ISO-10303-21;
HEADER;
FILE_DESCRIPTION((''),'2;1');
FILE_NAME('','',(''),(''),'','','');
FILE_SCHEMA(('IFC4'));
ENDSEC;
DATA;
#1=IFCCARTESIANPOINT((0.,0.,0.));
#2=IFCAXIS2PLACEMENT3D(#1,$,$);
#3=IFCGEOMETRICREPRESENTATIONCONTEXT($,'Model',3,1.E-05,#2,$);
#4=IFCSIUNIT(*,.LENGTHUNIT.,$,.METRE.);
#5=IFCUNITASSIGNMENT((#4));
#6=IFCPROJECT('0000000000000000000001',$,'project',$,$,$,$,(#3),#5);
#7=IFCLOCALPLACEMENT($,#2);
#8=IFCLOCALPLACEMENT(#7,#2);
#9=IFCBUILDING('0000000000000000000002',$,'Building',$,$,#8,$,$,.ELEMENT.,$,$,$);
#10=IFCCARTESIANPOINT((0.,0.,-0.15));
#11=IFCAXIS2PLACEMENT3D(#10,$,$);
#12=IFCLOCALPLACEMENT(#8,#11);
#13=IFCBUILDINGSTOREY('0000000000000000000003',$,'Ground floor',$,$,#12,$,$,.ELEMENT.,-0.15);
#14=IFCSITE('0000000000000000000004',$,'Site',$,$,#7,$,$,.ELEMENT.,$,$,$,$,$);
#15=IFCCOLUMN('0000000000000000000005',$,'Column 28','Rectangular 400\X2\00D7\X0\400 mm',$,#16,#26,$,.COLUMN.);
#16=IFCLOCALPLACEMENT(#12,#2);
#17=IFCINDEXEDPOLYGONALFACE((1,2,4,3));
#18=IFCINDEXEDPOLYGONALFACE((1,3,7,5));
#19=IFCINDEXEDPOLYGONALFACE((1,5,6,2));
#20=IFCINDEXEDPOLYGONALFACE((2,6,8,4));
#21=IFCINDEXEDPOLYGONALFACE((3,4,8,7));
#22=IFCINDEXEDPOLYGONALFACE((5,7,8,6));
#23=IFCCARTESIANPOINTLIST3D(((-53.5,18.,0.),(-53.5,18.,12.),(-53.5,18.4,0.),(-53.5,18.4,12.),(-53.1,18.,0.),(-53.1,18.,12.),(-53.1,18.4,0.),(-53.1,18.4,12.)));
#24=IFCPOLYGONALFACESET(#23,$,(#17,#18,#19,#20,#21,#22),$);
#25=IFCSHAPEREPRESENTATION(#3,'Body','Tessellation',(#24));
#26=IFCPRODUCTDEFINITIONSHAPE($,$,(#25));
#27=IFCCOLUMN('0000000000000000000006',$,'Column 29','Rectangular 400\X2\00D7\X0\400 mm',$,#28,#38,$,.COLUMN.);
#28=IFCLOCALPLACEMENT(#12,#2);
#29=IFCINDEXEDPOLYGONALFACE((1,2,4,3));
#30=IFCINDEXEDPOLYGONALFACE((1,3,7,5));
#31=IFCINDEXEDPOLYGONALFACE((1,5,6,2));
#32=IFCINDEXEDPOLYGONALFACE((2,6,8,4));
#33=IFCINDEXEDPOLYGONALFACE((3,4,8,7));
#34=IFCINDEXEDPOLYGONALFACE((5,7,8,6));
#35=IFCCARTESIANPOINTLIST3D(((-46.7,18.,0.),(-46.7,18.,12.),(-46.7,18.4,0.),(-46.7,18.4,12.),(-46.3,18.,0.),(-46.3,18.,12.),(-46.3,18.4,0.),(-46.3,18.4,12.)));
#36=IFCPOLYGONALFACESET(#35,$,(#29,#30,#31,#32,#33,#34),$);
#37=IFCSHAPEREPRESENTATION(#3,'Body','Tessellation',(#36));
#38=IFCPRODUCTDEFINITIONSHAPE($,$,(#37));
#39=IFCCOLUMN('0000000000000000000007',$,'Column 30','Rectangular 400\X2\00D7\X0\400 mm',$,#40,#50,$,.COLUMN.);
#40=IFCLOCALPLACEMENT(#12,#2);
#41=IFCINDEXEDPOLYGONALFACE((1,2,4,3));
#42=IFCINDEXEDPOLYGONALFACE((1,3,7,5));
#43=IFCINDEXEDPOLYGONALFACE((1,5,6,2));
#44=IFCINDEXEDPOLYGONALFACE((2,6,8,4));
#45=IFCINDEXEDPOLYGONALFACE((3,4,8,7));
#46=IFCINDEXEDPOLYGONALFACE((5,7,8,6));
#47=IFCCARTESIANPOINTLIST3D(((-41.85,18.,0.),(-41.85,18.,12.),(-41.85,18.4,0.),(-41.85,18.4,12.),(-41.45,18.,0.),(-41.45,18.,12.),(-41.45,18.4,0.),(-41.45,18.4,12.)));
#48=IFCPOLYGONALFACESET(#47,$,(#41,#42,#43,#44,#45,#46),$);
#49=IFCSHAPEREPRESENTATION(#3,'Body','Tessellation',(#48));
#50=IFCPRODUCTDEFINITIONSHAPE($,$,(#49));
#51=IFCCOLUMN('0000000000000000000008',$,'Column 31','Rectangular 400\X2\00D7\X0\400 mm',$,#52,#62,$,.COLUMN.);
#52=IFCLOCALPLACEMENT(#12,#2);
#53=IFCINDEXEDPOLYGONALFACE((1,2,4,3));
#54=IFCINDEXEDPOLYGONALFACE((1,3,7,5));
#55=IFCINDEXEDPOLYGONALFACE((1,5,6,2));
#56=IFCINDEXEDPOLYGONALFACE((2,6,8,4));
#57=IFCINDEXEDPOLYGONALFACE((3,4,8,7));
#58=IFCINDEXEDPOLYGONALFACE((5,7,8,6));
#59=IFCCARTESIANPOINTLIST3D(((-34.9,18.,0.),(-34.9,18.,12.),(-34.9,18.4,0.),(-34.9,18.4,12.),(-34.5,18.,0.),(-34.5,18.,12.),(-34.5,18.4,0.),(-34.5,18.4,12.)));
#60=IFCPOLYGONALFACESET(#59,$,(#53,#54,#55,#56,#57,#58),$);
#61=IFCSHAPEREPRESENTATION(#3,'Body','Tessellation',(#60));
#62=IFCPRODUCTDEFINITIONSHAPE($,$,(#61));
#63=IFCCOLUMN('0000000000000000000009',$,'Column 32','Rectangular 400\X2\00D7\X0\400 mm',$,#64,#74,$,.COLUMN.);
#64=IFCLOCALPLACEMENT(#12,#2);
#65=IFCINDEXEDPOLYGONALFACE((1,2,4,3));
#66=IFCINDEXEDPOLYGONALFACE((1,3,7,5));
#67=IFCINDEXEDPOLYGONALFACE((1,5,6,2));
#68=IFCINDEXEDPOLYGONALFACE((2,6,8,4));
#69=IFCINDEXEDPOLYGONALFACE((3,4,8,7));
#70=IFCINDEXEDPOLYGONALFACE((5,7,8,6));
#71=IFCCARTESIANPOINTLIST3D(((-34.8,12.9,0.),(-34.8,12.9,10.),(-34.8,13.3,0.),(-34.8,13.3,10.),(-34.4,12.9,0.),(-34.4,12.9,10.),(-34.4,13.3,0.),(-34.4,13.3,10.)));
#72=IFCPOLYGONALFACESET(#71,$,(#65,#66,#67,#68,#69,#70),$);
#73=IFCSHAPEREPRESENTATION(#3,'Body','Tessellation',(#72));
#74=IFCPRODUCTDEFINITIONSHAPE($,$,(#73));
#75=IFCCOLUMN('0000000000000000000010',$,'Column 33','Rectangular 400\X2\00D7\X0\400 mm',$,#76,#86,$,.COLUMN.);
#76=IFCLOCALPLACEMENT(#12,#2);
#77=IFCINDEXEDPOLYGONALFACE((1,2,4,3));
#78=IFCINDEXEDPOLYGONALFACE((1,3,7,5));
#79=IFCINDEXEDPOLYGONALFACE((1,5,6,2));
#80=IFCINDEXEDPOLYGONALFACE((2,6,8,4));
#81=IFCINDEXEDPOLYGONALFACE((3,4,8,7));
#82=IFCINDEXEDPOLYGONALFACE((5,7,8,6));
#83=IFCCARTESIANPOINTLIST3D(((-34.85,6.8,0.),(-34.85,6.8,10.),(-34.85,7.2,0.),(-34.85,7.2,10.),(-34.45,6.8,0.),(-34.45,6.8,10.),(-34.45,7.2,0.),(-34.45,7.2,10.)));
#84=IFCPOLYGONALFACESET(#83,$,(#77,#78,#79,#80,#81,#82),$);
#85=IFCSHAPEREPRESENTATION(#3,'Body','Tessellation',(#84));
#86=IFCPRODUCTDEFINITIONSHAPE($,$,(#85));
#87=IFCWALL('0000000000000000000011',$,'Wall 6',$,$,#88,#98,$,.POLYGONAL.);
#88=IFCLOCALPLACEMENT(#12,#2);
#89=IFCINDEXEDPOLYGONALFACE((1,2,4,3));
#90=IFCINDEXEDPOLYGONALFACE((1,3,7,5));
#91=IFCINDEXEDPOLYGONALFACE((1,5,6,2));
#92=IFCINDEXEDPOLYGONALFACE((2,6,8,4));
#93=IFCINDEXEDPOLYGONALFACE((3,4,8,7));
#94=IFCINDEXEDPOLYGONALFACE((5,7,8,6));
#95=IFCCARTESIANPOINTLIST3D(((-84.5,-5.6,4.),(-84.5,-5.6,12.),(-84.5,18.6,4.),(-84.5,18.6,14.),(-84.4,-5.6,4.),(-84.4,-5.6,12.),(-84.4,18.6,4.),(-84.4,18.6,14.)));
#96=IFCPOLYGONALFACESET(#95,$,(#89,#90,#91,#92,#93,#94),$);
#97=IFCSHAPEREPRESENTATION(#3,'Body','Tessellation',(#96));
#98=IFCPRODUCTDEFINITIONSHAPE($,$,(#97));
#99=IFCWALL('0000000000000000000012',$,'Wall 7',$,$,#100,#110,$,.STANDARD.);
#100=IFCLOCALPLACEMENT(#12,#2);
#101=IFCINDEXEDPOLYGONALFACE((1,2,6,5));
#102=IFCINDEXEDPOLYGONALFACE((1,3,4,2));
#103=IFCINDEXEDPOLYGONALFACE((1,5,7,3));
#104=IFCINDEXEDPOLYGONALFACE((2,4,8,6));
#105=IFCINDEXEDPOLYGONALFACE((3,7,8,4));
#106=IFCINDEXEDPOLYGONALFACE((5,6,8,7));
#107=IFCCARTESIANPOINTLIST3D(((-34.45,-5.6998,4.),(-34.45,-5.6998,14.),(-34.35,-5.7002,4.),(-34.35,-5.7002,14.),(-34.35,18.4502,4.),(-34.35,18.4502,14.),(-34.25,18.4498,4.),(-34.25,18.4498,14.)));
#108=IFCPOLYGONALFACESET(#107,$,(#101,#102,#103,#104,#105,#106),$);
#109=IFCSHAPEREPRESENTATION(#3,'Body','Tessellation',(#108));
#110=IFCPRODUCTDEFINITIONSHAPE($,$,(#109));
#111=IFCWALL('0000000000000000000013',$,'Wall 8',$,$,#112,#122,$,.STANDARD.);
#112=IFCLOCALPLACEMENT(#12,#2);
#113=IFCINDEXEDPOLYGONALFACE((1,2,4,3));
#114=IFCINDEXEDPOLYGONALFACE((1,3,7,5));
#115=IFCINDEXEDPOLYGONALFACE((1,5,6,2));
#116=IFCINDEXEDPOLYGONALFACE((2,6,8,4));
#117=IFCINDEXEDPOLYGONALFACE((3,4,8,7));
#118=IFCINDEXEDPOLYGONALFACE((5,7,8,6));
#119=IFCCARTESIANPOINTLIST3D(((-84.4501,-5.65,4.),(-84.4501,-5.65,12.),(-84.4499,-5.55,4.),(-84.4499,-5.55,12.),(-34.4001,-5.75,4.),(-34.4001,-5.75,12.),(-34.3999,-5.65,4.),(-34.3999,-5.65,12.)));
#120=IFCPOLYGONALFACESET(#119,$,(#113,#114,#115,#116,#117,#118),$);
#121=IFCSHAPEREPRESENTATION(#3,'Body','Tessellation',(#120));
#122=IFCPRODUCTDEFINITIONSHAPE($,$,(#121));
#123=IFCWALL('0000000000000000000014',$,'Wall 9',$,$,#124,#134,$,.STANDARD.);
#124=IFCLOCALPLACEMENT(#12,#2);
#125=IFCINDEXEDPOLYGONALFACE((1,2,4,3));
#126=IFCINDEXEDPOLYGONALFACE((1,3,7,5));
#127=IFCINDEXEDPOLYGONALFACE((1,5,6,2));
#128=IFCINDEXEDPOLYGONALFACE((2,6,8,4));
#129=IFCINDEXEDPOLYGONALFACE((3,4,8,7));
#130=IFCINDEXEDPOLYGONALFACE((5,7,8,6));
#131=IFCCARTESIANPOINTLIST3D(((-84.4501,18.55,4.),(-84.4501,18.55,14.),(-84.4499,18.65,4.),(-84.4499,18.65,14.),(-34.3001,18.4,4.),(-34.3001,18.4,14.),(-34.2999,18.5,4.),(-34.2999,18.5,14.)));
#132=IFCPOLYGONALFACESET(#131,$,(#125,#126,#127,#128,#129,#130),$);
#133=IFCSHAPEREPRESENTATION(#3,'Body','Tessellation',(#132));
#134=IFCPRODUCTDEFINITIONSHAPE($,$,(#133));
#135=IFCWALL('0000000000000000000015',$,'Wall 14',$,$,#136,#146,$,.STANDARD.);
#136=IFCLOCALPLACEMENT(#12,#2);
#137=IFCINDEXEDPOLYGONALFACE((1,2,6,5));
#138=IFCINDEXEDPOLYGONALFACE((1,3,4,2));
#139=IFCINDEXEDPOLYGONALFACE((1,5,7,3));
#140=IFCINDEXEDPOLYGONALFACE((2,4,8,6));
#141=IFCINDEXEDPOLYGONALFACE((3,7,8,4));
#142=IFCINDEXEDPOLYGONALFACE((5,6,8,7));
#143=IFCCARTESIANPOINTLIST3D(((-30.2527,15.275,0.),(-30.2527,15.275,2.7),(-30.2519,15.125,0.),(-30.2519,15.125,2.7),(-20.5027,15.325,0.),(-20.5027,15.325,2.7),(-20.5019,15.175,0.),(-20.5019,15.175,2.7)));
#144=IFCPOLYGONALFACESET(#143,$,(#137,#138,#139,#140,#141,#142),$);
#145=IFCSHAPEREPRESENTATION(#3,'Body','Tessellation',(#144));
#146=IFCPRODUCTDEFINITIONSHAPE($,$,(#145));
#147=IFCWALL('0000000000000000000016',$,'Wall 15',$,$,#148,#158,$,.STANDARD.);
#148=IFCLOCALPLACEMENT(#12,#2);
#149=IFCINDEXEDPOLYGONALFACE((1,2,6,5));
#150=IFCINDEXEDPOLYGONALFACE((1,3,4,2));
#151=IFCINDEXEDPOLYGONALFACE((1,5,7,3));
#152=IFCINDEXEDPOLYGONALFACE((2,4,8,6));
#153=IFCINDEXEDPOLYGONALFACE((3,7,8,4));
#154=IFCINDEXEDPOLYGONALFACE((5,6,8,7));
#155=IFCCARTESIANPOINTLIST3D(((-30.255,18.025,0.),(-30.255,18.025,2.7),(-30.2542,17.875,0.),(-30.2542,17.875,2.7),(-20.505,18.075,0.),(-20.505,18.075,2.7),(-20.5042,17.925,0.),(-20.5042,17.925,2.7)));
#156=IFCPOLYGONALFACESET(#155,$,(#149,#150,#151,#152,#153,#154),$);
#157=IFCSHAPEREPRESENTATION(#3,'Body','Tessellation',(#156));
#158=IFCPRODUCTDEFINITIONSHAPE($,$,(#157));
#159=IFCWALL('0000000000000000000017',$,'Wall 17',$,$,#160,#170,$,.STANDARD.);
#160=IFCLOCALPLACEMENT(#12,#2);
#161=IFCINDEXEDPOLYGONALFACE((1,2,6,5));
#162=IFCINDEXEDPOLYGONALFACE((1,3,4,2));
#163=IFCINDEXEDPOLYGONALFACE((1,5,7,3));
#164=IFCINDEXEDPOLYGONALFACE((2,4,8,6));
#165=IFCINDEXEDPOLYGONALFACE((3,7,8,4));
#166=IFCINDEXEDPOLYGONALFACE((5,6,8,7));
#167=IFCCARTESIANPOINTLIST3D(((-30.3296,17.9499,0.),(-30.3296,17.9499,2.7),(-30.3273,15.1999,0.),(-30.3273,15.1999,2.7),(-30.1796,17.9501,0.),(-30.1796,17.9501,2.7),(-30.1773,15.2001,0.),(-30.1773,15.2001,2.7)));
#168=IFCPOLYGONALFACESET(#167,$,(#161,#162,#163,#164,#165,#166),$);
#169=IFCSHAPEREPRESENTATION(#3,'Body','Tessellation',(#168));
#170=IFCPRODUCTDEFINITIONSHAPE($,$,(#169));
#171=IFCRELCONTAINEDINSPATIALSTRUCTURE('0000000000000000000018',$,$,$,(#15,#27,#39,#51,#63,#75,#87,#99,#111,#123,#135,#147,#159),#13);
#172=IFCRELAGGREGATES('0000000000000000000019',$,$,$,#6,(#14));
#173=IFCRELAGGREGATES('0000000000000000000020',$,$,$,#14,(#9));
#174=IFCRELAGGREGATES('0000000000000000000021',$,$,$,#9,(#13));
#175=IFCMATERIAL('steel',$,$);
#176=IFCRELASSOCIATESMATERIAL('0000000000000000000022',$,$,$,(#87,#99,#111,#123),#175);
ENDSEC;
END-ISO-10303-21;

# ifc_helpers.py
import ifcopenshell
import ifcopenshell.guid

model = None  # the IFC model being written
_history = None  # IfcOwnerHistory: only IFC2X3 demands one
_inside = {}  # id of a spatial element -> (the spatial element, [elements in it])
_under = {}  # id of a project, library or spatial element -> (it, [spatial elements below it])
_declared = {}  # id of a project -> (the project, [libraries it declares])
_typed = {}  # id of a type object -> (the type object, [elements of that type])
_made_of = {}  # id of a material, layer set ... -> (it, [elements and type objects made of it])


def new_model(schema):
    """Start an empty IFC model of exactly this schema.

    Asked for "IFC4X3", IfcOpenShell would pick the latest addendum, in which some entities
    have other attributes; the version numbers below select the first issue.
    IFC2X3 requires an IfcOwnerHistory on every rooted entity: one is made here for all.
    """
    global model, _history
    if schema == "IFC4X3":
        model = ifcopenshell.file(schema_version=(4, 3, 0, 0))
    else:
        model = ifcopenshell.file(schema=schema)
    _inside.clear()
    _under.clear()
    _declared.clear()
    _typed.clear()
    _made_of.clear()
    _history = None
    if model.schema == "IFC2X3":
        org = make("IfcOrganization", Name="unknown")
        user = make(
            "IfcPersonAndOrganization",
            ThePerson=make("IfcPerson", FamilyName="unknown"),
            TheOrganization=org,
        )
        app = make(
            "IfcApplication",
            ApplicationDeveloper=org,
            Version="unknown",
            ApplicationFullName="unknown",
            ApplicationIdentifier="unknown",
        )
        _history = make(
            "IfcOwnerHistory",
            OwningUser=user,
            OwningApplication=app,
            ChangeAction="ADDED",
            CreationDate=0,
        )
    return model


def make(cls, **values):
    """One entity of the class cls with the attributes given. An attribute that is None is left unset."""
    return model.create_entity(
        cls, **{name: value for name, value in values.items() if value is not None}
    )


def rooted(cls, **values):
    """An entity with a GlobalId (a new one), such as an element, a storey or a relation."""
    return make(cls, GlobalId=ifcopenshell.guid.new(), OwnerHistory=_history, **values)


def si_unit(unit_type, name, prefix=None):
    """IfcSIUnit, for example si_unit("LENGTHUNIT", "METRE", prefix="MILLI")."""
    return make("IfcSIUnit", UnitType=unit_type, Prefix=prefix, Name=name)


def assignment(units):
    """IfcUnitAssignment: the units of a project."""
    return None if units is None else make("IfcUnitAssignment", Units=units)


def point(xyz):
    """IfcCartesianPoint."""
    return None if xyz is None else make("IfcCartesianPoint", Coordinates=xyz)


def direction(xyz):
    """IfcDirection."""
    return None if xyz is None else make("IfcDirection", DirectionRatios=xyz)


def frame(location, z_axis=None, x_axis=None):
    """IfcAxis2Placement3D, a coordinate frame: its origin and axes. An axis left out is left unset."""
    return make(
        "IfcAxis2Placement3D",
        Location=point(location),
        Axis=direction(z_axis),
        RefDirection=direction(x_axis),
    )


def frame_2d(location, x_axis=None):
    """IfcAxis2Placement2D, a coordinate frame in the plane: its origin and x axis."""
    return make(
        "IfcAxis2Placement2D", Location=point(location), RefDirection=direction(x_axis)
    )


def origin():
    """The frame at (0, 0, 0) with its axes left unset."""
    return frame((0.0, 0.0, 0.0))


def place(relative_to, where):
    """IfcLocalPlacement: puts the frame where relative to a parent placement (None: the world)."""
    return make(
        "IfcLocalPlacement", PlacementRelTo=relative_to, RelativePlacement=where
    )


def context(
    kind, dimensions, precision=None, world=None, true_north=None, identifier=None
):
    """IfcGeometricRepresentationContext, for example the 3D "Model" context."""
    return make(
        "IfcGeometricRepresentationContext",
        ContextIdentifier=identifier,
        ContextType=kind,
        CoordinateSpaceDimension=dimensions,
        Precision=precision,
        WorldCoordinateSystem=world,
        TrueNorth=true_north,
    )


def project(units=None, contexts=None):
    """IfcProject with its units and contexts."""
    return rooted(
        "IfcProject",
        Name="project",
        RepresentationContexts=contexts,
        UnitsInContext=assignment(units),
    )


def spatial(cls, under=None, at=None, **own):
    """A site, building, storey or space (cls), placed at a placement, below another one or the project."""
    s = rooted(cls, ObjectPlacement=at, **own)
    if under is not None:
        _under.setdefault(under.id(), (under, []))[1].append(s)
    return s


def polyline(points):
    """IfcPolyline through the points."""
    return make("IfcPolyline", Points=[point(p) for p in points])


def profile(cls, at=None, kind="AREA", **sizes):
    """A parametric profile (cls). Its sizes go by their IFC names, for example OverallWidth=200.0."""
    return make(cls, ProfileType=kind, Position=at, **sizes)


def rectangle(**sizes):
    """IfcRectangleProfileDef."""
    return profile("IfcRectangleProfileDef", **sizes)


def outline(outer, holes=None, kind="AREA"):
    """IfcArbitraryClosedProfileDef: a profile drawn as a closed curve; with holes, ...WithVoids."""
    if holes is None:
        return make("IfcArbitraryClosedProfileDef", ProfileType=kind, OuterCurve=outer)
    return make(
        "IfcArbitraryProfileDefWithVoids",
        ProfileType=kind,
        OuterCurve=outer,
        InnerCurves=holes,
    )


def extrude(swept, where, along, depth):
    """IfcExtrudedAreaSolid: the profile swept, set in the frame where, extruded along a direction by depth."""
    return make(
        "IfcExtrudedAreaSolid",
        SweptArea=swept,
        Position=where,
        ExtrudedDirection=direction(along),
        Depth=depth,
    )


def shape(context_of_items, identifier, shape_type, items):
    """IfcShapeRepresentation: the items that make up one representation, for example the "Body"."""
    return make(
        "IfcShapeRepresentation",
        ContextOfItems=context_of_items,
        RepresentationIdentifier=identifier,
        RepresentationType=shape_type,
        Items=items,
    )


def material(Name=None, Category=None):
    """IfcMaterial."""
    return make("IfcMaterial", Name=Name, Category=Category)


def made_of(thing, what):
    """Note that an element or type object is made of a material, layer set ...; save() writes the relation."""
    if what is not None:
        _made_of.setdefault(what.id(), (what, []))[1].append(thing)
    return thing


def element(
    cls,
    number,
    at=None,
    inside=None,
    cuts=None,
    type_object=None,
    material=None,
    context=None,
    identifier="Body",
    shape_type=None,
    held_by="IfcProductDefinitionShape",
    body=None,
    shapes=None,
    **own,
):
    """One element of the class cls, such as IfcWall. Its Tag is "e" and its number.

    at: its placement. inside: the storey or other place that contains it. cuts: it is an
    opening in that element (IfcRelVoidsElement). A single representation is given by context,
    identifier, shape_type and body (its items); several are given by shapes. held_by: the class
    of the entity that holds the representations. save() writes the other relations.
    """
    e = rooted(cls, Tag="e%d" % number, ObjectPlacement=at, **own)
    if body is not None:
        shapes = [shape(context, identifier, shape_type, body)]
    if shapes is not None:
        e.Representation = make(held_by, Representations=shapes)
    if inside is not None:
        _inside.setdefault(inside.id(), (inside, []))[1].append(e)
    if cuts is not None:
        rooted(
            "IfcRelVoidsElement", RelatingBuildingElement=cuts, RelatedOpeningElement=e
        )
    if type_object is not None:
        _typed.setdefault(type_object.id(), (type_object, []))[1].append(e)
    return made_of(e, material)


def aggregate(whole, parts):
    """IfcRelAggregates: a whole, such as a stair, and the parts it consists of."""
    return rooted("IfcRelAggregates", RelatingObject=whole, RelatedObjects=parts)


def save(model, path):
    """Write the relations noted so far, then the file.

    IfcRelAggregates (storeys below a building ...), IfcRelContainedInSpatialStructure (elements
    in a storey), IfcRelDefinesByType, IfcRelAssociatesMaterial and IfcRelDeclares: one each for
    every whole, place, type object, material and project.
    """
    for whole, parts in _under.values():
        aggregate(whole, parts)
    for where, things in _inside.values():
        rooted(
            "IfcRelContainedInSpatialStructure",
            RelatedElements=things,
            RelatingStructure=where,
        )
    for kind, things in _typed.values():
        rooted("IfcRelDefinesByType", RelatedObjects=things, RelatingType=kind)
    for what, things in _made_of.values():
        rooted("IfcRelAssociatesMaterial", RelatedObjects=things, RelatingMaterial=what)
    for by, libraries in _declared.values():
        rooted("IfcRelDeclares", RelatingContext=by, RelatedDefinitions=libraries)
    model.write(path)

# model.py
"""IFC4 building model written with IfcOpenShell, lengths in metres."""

from ifc_helpers import new_model, si_unit, frame, frame_2d, origin, place, context, project, spatial, polyline, rectangle, outline, extrude, material, element, save


model = new_model("IFC4")

# Units and contexts
model_context = context("Model", 3, precision=1e-05, world=origin())
ifc_project = project(units=[si_unit("LENGTHUNIT", "METRE")], contexts=[model_context])

# Site, building, storey
site_placement = place(None, origin())
site = spatial("IfcSite", under=ifc_project, at=site_placement, Name="Site", CompositionType="ELEMENT")
building_placement = place(site_placement, origin())
building = spatial("IfcBuilding", under=site, at=building_placement, Name="Building", CompositionType="ELEMENT")
storey_placement = place(building_placement, frame((0.0, 0.0, -0.15)))
storey = spatial("IfcBuildingStorey", under=building, at=storey_placement, Name="Ground floor", CompositionType="ELEMENT", Elevation=-0.15)

# Columns
for number, where, z_axis, x_axis, name in (
    (1, (-53.3, 18.2, 0.0), (0.0, 0.0, 1.0), (1.0, 0.0, 0.0), "Column 28"),
    (2, (-46.5, 18.2, 0.0), (0.0, 0.0, 1.0), (1.0, 0.0, 0.0), "Column 29"),
    (3, (-41.65, 18.2, 0.0), (0.0, 0.0, 1.0), (1.0, 0.0, 0.0), "Column 30"),
    (4, (-34.7, 18.2, 0.0), (0.0, 0.0, 1.0), (1.0, 0.0, 0.0), "Column 31"),
):
    element("IfcColumn", number, at=place(storey_placement, frame(where, z_axis=z_axis, x_axis=x_axis)), inside=storey, Name=name, Description="Rectangular 400×400 mm", PredefinedType="COLUMN", context=model_context, shape_type="SweptSolid", body=[
        extrude(outline(polyline([(-0.2, -0.2), (0.2, -0.2), (0.2, 0.2), (-0.2, 0.2), (-0.2, -0.2)])), origin(), (0.0, 0.0, 1.0), 12.0),
    ])
for number, where, z_axis, x_axis, name in (
    (5, (-34.6, 13.1, 0.0), (0.0, 0.0, 1.0), (1.0, 0.0, 0.0), "Column 32"),
    (6, (-34.65, 7.0, 0.0), (0.0, 0.0, 1.0), (1.0, 0.0, 0.0), "Column 33"),
):
    element("IfcColumn", number, at=place(storey_placement, frame(where, z_axis=z_axis, x_axis=x_axis)), inside=storey, Name=name, Description="Rectangular 400×400 mm", PredefinedType="COLUMN", context=model_context, shape_type="SweptSolid", body=[
        extrude(outline(polyline([(-0.2, -0.2), (0.2, -0.2), (0.2, 0.2), (-0.2, 0.2), (-0.2, -0.2)])), origin(), (0.0, 0.0, 1.0), 10.0),
    ])

# Walls
ifc_material = material(Name="steel")
wall_1_placement = place(storey_placement, frame((-84.45, -5.6, 4.0), z_axis=(0.0, 0.0, 1.0), x_axis=(0.0, 1.0, 0.0)))
element("IfcWall", 7, at=wall_1_placement, inside=storey, material=ifc_material, Name="Wall 6", PredefinedType="POLYGONAL", context=model_context, shape_type="SweptSolid", body=[
    extrude(outline(polyline([(0.0, 0.0), (24.2, 0.0), (24.2, 10.0), (0.0, 8.0), (0.0, 0.0)])), frame((0.0, 0.05, 0.0), z_axis=(0.0, -1.0, 0.0), x_axis=(1.0, 0.0, 0.0)), (0.0, 0.0, 1.0), 0.1),
])
wall_2_placement = place(storey_placement, frame((-34.4, -5.7, 4.0), z_axis=(0.0, 0.0, 1.0), x_axis=(0.004141, 0.999991, 0.0)))
element("IfcWall", 8, at=wall_2_placement, inside=storey, material=ifc_material, Name="Wall 7", PredefinedType="STANDARD", context=model_context, shape_type="SweptSolid", body=[
    extrude(rectangle(XDim=24.1502, YDim=0.1, at=frame_2d((12.0751, 0.0))), origin(), (0.0, 0.0, 1.0), 10.0),
])
wall_3_placement = place(storey_placement, frame((-34.4, -5.7, 4.0), z_axis=(0.0, 0.0, 1.0), x_axis=(-0.999998, 0.001998, 0.0)))
element("IfcWall", 9, at=wall_3_placement, inside=storey, material=ifc_material, Name="Wall 8", PredefinedType="STANDARD", context=model_context, shape_type="SweptSolid", body=[
    extrude(rectangle(XDim=50.0501, YDim=0.1, at=frame_2d((25.0251, 0.0))), origin(), (0.0, 0.0, 1.0), 8.0),
])
wall_4_placement = place(storey_placement, frame((-34.3, 18.45, 4.0), z_axis=(0.0, 0.0, 1.0), x_axis=(-0.999996, 0.002991, 0.0)))
element("IfcWall", 10, at=wall_4_placement, inside=storey, material=ifc_material, Name="Wall 9", PredefinedType="STANDARD", context=model_context, shape_type="SweptSolid", body=[
    extrude(rectangle(XDim=50.1502, YDim=0.1, at=frame_2d((25.0751, 0.0))), origin(), (0.0, 0.0, 1.0), 10.0),
])
for number, where, z_axis, x_axis, name in (
    (11, (-30.2523, 15.2, 0.0), (0.0, 0.0, 1.0), (0.999987, 0.005128, 0.0), "Wall 14"),
    (12, (-30.2546, 17.95, 0.0), (0.0, 0.0, 1.0), (0.999987, 0.005128, 0.0), "Wall 15"),
):
    element("IfcWall", number, at=place(storey_placement, frame(where, z_axis=z_axis, x_axis=x_axis)), inside=storey, Name=name, PredefinedType="STANDARD", context=model_context, shape_type="SweptSolid", body=[
        extrude(rectangle(XDim=9.7501, YDim=0.15, at=frame_2d((4.8751, 0.0))), origin(), (0.0, 0.0, 1.0), 2.7),
    ])
wall_5_placement = place(storey_placement, frame((-30.2546, 17.95, 0.0), z_axis=(0.0, 0.0, 1.0), x_axis=(0.000839, -1.0, 0.0)))
element("IfcWall", 13, at=wall_5_placement, inside=storey, Name="Wall 17", PredefinedType="STANDARD", context=model_context, shape_type="SweptSolid", body=[
    extrude(rectangle(XDim=2.75, YDim=0.15, at=frame_2d((1.375, 0.0))), origin(), (0.0, 0.0, 1.0), 2.7),
])

save(model, "model.ifc")
